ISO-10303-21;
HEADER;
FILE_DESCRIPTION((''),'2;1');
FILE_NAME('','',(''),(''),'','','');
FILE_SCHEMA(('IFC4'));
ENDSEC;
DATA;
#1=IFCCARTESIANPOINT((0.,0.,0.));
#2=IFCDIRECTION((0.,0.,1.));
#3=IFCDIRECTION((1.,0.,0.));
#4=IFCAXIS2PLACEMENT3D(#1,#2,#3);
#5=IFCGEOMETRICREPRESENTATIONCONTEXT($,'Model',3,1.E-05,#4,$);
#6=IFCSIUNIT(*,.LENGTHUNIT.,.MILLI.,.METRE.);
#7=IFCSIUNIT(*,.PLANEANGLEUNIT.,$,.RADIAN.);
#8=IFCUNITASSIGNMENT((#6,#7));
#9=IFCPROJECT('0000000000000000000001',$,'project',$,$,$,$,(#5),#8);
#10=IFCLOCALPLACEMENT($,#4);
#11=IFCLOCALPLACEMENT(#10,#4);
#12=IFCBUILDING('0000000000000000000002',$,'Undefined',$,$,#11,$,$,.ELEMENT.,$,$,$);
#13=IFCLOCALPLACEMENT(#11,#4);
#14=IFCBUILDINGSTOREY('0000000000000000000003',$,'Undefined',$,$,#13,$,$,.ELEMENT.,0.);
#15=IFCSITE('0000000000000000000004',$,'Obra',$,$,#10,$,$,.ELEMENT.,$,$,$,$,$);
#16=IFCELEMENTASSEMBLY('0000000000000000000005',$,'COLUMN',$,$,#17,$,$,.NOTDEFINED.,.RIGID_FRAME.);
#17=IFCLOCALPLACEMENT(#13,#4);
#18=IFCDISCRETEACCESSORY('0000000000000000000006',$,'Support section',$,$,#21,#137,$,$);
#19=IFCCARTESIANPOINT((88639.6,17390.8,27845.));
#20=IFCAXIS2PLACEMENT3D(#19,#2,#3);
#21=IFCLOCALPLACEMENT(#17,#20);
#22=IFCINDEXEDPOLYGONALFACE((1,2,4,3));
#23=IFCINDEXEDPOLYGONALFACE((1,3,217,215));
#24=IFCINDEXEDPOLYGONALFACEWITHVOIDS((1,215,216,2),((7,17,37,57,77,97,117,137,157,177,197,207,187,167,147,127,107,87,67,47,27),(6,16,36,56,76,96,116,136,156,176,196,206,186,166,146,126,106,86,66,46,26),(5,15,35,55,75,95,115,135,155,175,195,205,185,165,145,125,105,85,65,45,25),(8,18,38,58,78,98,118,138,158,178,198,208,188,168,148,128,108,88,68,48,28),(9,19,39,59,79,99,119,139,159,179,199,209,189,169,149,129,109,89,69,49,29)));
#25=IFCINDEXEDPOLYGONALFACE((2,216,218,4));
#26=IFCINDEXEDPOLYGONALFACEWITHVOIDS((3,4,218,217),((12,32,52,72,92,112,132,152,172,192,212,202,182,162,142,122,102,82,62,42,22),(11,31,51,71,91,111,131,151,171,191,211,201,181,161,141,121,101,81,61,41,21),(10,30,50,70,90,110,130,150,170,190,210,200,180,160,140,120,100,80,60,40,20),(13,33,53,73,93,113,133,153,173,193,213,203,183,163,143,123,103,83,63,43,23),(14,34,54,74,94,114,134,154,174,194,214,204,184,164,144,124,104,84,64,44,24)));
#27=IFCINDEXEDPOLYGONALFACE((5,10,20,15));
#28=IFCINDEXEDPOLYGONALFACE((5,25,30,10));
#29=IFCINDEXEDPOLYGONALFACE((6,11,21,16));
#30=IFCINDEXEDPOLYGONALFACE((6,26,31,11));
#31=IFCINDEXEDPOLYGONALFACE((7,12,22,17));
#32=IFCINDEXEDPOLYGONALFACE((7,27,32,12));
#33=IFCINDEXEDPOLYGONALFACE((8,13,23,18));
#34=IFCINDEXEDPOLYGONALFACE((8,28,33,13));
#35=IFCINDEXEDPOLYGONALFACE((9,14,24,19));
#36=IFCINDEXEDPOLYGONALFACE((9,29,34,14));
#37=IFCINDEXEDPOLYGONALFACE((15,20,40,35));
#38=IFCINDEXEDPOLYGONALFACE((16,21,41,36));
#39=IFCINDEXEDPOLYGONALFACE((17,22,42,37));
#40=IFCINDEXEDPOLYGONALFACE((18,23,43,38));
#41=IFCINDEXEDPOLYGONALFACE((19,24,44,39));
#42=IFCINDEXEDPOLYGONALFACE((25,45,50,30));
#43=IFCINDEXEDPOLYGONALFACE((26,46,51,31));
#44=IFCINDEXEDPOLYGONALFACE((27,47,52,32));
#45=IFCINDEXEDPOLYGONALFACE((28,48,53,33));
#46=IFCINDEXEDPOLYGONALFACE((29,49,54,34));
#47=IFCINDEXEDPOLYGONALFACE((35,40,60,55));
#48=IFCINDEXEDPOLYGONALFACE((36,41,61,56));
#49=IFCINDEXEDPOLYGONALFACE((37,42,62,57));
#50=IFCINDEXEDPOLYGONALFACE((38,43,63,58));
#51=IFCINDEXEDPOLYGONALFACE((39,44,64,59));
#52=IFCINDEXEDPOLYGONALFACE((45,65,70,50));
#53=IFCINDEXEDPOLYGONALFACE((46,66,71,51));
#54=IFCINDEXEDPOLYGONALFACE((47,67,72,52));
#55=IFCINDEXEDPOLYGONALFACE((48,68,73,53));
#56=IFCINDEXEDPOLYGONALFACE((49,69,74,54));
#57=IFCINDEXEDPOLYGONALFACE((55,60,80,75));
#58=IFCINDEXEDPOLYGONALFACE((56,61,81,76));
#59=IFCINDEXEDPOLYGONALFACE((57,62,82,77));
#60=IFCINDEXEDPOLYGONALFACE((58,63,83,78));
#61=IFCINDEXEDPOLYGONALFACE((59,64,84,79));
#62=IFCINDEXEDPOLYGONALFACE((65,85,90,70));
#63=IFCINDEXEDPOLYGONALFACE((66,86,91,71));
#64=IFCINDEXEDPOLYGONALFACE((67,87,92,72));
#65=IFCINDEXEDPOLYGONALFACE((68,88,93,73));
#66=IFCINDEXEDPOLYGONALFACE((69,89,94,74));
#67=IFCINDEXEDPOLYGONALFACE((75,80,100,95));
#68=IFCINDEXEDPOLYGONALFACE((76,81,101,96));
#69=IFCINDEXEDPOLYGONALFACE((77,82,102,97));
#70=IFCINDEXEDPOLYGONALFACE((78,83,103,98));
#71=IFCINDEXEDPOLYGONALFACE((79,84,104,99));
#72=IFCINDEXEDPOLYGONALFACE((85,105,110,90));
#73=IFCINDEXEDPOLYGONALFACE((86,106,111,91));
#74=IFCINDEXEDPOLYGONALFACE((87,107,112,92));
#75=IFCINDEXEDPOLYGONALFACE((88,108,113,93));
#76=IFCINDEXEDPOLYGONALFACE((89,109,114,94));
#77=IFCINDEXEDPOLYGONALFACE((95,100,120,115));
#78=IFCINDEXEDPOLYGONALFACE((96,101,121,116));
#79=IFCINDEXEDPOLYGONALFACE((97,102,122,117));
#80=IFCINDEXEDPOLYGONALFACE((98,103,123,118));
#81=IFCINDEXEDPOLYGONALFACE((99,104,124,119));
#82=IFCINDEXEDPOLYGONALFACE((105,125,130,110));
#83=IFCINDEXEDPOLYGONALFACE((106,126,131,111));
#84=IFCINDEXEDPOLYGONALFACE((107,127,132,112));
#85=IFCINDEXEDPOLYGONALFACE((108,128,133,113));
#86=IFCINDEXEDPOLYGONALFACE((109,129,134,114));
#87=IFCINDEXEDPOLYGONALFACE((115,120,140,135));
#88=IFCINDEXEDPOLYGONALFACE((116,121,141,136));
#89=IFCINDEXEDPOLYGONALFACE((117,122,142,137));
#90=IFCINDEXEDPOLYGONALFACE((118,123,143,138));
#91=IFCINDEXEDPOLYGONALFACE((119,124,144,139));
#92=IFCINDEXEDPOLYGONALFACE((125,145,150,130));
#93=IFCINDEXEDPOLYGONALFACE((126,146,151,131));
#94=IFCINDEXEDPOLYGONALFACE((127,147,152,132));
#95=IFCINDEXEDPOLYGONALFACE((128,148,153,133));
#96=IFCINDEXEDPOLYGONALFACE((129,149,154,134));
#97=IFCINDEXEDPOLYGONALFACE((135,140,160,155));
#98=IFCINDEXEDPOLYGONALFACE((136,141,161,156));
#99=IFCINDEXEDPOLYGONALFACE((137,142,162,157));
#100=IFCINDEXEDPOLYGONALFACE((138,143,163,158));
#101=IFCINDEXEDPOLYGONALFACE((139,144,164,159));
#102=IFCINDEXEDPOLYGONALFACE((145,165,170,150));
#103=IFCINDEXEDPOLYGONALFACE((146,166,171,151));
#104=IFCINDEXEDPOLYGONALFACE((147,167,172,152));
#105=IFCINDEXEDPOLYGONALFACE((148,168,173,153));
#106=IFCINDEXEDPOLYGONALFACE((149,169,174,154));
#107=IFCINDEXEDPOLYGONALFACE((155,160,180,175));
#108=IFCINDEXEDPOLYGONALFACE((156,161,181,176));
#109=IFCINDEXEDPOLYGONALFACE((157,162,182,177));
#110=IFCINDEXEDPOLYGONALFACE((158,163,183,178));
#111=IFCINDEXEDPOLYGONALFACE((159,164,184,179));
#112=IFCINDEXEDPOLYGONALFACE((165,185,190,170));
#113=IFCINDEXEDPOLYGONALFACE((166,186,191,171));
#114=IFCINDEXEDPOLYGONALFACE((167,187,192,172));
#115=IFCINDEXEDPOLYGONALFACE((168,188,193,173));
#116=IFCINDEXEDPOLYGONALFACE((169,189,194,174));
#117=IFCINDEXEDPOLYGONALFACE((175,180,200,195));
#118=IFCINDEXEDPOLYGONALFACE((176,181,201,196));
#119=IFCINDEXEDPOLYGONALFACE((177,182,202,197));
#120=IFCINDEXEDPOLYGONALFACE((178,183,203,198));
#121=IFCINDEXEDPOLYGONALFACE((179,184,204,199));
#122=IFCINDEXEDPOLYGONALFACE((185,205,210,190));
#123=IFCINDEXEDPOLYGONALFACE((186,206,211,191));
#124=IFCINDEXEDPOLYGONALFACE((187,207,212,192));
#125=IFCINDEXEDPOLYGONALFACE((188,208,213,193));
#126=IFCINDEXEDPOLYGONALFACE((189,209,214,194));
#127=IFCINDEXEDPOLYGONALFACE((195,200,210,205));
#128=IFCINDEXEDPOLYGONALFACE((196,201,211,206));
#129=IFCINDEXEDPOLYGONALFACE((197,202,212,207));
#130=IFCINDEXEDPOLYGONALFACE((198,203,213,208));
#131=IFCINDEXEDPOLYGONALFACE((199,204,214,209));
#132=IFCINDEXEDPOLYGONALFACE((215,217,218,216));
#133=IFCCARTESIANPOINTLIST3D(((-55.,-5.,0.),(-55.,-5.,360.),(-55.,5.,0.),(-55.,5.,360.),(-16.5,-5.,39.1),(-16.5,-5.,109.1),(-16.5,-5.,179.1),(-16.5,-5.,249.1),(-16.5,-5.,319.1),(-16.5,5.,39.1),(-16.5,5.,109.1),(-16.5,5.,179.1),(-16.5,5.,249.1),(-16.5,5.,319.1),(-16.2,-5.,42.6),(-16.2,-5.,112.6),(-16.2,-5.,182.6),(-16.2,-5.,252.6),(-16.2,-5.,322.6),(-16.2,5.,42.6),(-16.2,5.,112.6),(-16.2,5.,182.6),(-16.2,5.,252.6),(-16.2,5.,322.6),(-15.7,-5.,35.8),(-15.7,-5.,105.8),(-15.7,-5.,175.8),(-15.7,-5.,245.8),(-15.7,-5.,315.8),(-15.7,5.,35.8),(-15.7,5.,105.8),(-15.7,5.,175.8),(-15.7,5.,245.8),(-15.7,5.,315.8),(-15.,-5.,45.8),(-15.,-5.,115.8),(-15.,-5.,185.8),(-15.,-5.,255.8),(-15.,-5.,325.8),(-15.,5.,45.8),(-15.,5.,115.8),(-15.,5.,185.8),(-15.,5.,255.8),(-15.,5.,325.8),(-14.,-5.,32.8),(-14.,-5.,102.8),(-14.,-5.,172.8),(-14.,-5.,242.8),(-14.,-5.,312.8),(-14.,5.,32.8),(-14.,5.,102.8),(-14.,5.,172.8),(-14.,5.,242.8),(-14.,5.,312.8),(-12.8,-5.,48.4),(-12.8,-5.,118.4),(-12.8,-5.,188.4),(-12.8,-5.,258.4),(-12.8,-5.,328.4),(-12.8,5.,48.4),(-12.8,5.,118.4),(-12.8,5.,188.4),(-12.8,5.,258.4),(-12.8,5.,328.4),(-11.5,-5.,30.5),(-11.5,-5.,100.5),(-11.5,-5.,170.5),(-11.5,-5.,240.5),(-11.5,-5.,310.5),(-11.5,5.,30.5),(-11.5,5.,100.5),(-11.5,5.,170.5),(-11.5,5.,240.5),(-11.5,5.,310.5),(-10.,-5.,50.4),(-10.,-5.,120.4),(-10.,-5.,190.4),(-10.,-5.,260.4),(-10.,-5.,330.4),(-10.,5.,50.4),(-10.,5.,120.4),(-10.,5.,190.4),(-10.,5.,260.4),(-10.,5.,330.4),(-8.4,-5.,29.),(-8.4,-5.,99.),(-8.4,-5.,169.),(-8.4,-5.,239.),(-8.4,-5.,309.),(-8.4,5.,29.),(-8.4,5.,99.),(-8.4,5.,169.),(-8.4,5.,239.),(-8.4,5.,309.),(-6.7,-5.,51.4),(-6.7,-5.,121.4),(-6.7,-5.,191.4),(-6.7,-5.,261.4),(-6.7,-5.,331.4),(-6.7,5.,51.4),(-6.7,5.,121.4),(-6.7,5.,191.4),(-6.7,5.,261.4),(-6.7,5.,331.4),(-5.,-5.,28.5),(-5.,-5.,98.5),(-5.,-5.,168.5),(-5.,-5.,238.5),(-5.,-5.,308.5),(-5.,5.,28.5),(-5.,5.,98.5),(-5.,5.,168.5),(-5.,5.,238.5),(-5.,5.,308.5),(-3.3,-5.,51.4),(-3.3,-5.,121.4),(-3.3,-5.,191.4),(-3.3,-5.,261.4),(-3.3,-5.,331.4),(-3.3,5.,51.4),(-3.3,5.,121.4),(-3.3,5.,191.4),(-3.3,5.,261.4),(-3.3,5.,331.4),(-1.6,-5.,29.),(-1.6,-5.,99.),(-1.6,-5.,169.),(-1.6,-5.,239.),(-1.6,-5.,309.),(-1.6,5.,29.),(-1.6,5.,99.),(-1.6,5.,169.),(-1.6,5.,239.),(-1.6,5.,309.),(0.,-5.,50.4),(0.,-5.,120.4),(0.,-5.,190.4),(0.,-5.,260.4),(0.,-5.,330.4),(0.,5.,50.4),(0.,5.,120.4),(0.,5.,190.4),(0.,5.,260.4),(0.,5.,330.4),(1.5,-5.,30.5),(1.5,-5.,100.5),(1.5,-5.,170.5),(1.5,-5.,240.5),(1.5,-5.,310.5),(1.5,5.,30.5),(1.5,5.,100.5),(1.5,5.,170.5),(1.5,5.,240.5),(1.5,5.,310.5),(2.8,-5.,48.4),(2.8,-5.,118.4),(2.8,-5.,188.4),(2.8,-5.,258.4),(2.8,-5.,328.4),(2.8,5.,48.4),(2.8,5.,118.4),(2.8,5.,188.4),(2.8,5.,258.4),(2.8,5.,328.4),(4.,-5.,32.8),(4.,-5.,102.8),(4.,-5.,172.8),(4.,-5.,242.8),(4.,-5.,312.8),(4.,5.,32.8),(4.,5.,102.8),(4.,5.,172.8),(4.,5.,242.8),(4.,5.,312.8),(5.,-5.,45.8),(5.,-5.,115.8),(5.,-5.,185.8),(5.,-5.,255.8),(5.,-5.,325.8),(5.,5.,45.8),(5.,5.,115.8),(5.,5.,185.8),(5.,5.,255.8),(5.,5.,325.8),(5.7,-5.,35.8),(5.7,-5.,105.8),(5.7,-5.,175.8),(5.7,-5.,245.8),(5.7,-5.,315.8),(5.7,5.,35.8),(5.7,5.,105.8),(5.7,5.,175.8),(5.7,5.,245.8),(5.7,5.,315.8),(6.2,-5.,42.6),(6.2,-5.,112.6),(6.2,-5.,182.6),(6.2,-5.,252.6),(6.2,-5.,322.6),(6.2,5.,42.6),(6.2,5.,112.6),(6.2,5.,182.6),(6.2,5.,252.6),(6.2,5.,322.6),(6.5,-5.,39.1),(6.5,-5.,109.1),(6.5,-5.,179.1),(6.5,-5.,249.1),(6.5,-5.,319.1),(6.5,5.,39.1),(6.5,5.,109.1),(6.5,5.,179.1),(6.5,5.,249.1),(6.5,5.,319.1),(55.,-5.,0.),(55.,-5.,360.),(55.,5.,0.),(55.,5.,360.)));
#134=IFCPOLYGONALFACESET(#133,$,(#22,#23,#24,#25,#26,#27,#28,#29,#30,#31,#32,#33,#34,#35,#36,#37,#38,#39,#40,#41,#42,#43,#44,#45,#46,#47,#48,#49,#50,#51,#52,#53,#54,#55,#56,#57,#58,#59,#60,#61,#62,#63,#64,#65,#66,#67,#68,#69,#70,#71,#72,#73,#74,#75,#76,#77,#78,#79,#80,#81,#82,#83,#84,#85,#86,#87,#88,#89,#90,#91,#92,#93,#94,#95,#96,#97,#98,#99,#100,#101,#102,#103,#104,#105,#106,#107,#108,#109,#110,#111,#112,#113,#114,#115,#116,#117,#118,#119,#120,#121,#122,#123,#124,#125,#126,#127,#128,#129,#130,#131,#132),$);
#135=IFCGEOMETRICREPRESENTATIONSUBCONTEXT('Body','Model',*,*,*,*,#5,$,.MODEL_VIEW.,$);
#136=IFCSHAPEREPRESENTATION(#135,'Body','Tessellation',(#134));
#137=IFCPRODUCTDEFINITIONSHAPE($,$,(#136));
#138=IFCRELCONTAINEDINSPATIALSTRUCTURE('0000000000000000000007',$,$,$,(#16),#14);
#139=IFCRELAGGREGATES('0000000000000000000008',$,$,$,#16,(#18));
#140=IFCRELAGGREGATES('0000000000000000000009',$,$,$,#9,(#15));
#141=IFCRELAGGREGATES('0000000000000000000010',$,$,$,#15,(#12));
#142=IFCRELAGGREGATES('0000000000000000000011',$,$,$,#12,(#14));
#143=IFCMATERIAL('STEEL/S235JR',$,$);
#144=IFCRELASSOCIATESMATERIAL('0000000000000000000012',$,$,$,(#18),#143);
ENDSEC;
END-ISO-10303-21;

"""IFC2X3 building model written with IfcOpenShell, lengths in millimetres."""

from ifc_helpers import new_model, si_unit, frame, origin_with_axes, origin_2d_with_axis, place, context, subcontext, project, spatial, rectangle, circle, extrude, source, transform, mapped, material, element, aggregate, save


model = new_model("IFC2X3")

# Units and contexts
model_context = context("Model", 3, precision=1e-05, world=origin_with_axes())
body_context = subcontext(model_context, "Body", "Model", "MODEL_VIEW")
ifc_project = project(units=[si_unit("LENGTHUNIT", "METRE", prefix="MILLI"), si_unit("PLANEANGLEUNIT", "RADIAN")], contexts=[model_context])

# Site, building, storey
site_placement = place(None, origin_with_axes())
site = spatial("IfcSite", under=ifc_project, at=site_placement, Name="Obra", CompositionType="ELEMENT")
building_placement = place(site_placement, origin_with_axes())
building = spatial("IfcBuilding", under=site, at=building_placement, Name="Undefined", CompositionType="ELEMENT")
storey_placement = place(building_placement, origin_with_axes())
storey = spatial("IfcBuildingStorey", under=building, at=storey_placement, Name="Undefined", CompositionType="ELEMENT", Elevation=0.0)

# Shared definitions
ifc_material = material(Name="STEEL/S235JR")

# Element assembly, discrete accessory, opening
assembly_1_placement = place(storey_placement, origin_with_axes())
assembly_1 = element("IfcElementAssembly", 1, at=assembly_1_placement, inside=storey, Name="COLUMN", AssemblyPlace="NOTDEFINED", PredefinedType="RIGID_FRAME")
discrete_accessory_1_placement = place(assembly_1_placement, frame((88639.6, 17390.8, 27845.0), z_axis=(0.0, 0.0, 1.0), x_axis=(1.0, 0.0, 0.0)))
discrete_accessory_1 = element("IfcDiscreteAccessory", 2, at=discrete_accessory_1_placement, material=ifc_material, Name="Support section", context=body_context, shape_type="SweptSolid", body=[
    extrude(rectangle(XDim=10.0, YDim=110.0, at=origin_2d_with_axis()), frame((0.0, 0.0, 360.0), z_axis=(0.0, 0.0, -1.0), x_axis=(0.0, 1.0, 0.0)), (0.0, 0.0, 1.0), 360.0),
])
shared_shape_1 = source(origin_with_axes(), body_context, "Body", "SweptSolid", [
    extrude(circle(Radius=11.5, at=origin_2d_with_axis()), frame((0.0, -15.7, 0.0), z_axis=(0.0, 1.0, 0.0), x_axis=(1.0, 0.0, 0.0)), (0.0, 0.0, 1.0), 10.2),
])
opening_1_placement = place(assembly_1_placement, frame((88684.6, 17380.2, 28300.0), z_axis=(-1.0, 0.0, 0.0), x_axis=(0.0, 0.0, -1.0)))
element("IfcOpeningElement", 3, at=opening_1_placement, cuts=discrete_accessory_1, ObjectType="Opening", context=body_context, shape_type="MappedRepresentation", body=[
    mapped(shared_shape_1, transform((135.0, 0.0, 50.0))),
    mapped(shared_shape_1, transform((205.0, 0.0, 50.0))),
    mapped(shared_shape_1, transform((275.0, 0.0, 50.0))),
    mapped(shared_shape_1, transform((345.0, 0.0, 50.0))),
    mapped(shared_shape_1, transform((415.0, 0.0, 50.0))),
])
aggregate(assembly_1, [discrete_accessory_1])

save(model, "model.ifc")
